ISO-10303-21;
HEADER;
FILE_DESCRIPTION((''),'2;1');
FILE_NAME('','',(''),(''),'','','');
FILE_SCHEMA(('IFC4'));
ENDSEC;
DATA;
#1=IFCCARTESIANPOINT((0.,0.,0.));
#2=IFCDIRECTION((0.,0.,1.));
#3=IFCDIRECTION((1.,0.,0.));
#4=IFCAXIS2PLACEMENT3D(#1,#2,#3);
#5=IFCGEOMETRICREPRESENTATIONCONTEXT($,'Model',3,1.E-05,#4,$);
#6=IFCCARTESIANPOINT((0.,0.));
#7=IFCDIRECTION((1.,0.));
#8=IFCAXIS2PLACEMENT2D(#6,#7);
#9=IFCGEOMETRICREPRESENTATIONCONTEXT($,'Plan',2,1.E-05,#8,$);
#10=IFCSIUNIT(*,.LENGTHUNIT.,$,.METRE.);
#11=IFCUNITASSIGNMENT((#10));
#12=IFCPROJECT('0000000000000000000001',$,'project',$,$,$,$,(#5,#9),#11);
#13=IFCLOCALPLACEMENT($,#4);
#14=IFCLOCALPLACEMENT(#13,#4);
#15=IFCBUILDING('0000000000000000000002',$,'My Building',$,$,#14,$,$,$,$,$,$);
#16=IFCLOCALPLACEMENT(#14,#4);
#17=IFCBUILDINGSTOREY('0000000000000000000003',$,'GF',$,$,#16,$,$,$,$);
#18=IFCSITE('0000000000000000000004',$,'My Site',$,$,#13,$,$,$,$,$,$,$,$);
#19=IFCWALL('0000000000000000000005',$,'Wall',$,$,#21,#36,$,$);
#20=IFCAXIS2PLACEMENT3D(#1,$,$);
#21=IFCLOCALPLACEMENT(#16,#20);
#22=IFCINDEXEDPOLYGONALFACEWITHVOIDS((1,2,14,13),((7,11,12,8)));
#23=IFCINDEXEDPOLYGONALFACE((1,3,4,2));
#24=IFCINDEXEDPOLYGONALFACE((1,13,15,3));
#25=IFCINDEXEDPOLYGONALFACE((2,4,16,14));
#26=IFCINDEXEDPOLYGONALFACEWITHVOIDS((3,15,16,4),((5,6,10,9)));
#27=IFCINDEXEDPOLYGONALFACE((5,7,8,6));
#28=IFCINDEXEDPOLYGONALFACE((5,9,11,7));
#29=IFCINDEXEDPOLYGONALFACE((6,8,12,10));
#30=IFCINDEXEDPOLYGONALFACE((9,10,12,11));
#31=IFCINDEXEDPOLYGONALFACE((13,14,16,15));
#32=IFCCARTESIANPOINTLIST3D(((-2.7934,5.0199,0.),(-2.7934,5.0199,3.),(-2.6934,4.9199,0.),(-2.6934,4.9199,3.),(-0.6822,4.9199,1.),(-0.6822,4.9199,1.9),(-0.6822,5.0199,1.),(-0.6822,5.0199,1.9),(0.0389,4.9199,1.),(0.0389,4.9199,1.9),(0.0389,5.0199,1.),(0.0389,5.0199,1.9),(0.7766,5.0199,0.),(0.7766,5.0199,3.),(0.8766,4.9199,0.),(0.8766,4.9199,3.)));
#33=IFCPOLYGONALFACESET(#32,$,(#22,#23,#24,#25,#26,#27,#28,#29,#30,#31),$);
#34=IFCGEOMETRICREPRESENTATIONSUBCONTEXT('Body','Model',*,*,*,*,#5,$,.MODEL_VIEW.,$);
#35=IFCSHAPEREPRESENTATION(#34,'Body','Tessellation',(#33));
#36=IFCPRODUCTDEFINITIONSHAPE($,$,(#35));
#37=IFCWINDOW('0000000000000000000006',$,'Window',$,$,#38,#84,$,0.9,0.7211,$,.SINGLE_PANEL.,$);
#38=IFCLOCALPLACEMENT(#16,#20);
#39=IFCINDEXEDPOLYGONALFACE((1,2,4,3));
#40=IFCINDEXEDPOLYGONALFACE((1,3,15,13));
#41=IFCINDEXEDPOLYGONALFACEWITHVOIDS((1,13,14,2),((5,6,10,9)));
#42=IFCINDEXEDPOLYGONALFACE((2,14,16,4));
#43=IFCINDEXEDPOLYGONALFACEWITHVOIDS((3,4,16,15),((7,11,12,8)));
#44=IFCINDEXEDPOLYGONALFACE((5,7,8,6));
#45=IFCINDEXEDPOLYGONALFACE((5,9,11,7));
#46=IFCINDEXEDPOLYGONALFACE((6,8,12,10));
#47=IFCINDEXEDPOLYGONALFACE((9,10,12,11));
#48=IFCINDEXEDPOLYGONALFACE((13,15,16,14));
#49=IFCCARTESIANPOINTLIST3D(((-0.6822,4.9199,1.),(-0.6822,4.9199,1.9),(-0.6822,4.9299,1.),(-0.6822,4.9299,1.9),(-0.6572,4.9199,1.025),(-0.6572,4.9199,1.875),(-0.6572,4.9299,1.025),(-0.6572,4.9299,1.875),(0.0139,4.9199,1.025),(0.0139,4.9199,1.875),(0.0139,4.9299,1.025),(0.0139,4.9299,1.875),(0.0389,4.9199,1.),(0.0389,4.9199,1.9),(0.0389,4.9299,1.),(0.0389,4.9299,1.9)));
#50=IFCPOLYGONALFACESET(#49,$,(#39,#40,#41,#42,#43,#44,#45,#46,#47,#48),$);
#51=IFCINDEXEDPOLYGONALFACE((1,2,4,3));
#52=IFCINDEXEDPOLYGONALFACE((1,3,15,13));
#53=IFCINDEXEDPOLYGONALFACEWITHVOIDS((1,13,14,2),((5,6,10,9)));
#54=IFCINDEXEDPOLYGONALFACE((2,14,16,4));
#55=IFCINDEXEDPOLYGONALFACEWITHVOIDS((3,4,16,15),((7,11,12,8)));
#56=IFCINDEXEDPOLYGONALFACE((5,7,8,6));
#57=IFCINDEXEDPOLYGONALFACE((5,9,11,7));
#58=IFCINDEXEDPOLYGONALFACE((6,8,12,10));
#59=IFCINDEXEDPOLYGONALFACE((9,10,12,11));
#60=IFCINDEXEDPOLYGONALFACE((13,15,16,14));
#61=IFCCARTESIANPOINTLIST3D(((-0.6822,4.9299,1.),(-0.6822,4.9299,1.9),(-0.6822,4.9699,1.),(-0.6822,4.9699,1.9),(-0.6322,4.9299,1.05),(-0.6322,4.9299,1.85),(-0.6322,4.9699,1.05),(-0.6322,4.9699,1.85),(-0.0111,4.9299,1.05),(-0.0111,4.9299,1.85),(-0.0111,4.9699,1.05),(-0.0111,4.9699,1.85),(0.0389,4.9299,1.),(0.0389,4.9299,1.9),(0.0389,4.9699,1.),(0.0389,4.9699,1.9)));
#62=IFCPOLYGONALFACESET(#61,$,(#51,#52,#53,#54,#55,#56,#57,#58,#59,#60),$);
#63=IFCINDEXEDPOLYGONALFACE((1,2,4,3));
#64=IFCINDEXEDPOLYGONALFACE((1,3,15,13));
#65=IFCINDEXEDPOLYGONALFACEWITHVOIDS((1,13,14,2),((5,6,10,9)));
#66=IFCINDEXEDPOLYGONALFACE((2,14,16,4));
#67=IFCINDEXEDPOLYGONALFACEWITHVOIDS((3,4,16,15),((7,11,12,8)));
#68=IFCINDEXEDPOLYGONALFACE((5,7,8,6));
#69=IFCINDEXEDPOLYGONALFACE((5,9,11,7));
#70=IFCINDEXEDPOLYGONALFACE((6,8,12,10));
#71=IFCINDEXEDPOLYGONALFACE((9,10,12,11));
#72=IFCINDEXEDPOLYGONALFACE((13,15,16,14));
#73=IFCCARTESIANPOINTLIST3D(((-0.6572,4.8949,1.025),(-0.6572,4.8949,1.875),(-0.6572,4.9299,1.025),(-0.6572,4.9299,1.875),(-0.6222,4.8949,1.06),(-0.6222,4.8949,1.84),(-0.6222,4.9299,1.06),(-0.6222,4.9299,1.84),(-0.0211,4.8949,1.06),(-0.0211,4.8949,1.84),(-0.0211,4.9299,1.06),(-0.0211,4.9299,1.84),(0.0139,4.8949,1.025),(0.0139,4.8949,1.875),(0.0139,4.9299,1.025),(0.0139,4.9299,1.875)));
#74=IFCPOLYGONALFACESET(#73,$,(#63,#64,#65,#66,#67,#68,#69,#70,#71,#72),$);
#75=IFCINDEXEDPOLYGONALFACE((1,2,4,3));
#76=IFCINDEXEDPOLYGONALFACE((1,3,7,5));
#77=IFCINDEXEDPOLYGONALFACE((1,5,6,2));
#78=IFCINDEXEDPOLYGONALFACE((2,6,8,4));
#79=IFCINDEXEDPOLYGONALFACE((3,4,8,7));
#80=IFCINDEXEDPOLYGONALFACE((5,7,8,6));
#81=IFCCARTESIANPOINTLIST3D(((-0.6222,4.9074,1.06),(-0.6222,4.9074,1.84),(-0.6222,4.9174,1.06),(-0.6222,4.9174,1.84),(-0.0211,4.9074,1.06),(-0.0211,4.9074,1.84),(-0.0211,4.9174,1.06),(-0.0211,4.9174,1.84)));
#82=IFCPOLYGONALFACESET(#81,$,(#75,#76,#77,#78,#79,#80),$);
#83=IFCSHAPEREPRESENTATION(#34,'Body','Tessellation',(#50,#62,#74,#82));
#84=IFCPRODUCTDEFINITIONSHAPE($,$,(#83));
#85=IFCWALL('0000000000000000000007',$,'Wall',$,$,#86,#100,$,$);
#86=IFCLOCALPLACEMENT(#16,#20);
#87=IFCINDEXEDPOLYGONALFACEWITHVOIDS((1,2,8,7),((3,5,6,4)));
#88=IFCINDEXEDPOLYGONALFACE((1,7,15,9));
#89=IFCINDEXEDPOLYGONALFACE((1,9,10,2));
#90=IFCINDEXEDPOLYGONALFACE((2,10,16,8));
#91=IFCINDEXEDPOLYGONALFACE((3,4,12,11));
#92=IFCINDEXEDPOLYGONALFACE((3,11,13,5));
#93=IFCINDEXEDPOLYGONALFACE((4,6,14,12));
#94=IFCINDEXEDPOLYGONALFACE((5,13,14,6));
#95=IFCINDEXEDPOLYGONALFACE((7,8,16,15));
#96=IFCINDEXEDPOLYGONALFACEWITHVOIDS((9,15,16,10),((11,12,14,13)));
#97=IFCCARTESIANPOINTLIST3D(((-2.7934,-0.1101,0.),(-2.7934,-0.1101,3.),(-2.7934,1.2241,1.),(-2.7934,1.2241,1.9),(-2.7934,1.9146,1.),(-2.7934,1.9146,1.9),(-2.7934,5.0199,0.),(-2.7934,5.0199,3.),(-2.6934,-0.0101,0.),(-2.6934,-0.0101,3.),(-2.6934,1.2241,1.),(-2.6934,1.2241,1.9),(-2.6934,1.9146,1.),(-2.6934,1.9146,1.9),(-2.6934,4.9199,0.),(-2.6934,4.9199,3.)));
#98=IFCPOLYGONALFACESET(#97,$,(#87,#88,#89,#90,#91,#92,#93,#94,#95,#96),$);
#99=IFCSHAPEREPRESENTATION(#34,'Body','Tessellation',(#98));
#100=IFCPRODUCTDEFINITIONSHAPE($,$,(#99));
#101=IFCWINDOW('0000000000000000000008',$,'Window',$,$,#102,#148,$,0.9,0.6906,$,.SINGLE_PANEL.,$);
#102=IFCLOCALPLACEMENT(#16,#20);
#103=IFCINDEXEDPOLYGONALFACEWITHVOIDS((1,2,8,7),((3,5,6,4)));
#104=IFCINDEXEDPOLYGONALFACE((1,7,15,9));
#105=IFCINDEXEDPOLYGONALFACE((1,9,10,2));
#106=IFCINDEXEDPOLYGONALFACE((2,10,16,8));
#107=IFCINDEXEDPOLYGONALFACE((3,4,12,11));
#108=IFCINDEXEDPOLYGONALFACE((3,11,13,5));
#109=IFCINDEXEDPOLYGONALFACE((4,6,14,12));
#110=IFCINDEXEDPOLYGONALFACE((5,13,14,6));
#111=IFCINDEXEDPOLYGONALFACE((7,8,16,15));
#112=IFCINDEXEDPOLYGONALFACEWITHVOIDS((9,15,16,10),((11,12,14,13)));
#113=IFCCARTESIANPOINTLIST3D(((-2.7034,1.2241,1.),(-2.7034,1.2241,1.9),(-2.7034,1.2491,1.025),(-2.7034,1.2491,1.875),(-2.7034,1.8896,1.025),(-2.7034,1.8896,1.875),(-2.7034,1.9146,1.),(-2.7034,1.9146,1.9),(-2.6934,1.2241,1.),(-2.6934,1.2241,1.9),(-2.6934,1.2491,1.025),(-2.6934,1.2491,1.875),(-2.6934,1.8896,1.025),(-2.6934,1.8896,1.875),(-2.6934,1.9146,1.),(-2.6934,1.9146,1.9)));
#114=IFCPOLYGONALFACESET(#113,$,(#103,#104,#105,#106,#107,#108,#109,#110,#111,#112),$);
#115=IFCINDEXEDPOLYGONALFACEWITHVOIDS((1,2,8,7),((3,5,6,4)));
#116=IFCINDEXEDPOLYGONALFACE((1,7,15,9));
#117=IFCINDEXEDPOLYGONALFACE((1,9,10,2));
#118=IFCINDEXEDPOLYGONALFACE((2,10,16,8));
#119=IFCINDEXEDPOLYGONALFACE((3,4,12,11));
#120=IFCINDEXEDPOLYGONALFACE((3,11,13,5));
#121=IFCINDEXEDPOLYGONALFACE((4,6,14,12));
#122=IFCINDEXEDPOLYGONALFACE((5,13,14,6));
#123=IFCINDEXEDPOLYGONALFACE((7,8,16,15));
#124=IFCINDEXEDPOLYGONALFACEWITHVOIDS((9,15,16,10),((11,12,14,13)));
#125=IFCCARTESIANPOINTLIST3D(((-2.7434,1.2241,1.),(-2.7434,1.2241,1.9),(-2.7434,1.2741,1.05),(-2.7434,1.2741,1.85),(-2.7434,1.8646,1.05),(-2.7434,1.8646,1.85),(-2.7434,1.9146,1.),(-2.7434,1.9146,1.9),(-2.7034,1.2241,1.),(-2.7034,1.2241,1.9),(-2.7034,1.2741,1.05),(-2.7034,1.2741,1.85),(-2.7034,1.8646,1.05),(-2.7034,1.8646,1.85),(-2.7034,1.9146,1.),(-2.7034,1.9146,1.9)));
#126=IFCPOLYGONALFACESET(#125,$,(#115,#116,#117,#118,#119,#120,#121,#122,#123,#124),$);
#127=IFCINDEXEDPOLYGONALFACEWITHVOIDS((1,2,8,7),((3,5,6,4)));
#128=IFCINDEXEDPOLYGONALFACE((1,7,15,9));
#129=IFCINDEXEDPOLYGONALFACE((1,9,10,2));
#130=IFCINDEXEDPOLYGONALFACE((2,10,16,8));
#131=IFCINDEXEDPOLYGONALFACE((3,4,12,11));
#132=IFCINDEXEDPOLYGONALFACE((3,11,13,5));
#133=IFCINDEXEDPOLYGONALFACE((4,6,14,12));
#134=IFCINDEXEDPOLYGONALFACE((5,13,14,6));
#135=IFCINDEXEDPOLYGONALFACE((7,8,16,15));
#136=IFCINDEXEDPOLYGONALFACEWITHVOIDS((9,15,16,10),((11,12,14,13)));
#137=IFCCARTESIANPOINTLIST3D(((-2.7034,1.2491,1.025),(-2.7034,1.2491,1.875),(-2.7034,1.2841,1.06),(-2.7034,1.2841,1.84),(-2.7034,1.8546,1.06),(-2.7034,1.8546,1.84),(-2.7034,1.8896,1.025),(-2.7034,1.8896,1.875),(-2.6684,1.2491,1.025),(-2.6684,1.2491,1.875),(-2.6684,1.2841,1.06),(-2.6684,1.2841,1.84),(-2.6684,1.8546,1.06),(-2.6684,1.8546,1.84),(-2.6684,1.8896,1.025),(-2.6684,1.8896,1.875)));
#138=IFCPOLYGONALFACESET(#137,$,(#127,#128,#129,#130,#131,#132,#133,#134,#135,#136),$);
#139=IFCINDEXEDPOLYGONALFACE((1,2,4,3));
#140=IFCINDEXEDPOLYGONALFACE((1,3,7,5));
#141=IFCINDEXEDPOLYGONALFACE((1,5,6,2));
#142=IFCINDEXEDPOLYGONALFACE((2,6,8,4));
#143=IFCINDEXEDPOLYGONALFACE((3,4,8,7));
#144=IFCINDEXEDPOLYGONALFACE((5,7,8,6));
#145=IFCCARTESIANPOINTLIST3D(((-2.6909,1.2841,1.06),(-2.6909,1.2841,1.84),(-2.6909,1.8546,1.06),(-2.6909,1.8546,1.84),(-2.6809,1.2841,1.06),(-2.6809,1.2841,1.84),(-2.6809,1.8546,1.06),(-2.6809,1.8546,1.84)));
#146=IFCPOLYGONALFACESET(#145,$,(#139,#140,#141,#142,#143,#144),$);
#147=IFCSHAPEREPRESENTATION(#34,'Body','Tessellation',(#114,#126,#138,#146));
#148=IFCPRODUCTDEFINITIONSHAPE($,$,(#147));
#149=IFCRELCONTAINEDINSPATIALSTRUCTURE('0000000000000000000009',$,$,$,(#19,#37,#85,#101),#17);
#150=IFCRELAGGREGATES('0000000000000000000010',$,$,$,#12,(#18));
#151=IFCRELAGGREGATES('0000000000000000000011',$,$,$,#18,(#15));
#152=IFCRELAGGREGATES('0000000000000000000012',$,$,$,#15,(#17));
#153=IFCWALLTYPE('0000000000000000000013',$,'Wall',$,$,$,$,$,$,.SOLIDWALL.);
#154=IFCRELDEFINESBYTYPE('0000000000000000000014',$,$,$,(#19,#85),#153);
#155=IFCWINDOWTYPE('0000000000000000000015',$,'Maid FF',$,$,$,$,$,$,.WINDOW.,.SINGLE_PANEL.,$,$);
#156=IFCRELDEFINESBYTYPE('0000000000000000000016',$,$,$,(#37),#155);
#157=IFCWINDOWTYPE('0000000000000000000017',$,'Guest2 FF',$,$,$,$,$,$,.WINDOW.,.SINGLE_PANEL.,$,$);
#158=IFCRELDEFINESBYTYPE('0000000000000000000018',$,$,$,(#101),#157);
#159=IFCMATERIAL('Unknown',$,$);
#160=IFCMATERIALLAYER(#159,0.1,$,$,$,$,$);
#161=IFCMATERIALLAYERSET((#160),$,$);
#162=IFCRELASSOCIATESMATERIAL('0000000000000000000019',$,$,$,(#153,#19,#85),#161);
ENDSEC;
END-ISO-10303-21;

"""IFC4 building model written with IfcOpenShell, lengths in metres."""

from ifc_helpers import new_model, entity, si_unit, frame, origin_with_axes, origin_2d_with_axis, place, context, subcontext, project, spatial, line, indexed_curve, outline, extrude, shape, source, transform, mapped, material, layer, layer_set, layer_usage, type_object, type_shapes, element, fill, save


model = new_model("IFC4")

# Units and contexts
model_context = context("Model", 3, precision=1e-05, world=origin_with_axes())
plan_context = context("Plan", 2, precision=1e-05, world=origin_2d_with_axis())
body_context_1 = subcontext(model_context, "Body", "Model", "MODEL_VIEW")
body_context_2 = subcontext(plan_context, "Body", "Plan", "PLAN_VIEW")
ifc_project = project(units=[si_unit("LENGTHUNIT", "METRE")], contexts=[model_context, plan_context])

# Site, building, storey
site_placement = place(None, origin_with_axes())
site = spatial("IfcSite", under=ifc_project, at=site_placement, Name="My Site")
building_placement = place(site_placement, origin_with_axes())
building = spatial("IfcBuilding", under=site, at=building_placement, Name="My Building")
storey_placement = place(building_placement, origin_with_axes())
storey = spatial("IfcBuildingStorey", under=building, at=storey_placement, Name="GF")

# Shared definitions
ifc_material_1 = material(Name="Unknown")

# Shared definitions
ifc_layer_1 = layer(ifc_material_1, 0.1)
ifc_layer_set_1 = layer_set([ifc_layer_1])
wall_type = type_object("IfcWallType", Name="Wall", PredefinedType="SOLIDWALL", material=ifc_layer_set_1)

# Walls, openings, windows
ifc_layer_usage_1 = layer_usage(ifc_layer_set_1, "AXIS2", "POSITIVE", 0.0)
wall_1_placement = place(storey_placement, frame((0.7766, 5.0199, 0.0), z_axis=(0.0, 0.0, 1.0), x_axis=(-1.0, 0.0, 0.0)))
wall_1 = element("IfcWall", 1, at=wall_1_placement, inside=storey, type_object=wall_type, material=ifc_layer_usage_1, Name="Wall", context=body_context_1, shape_type="SweptSolid", body=[
    extrude(outline(indexed_curve([(0.0, 0.0), (-0.1, 0.1), (3.47, 0.1), (3.57, 0.0)], segments=[line(1, 2, 3, 4, 1)])), origin_with_axes(), (0.0, 0.0, 1.0), 3.0),
])
shared_shape_1 = source(origin_with_axes(), body_context_1, "Body", "SweptSolid", [
    extrude(outline(indexed_curve([(0.0, 0.0), (0.7211, 0.0), (0.7211, 0.9), (0.0, 0.9)], segments=[line(1, 2, 3, 4, 1)])), frame((0.0, -0.6, 0.0), z_axis=(0.0, -1.0, 0.0), x_axis=(1.0, 0.0, 0.0)), (0.0, 0.0, -1.0), 1.2),
])
opening_1_placement = place(wall_1_placement, frame((0.7377, 0.0, 1.0), z_axis=(0.0, 0.0, 1.0), x_axis=(1.0, 0.0, 0.0)))
opening_1 = element("IfcOpeningElement", 2, at=opening_1_placement, cuts=wall_1, PredefinedType="OPENING", context=body_context_1, shape_type="MappedRepresentation", body=[
    mapped(shared_shape_1, transform((0.0, 0.0, 0.0), x_axis=(1.0, 0.0, 0.0), y_axis=(0.0, 1.0, 0.0), z_axis=(0.0, 0.0, 1.0), scale=1.0)),
])
window_type_1 = type_object("IfcWindowType", Name="Maid FF", PartitioningType="SINGLE_PANEL", PredefinedType="WINDOW")
shared_shape_2 = source(origin_with_axes(), body_context_1, "Body", "SweptSolid", [
    extrude(outline(indexed_curve([(0.0, 0.0), (0.7211, 0.0), (0.7211, 0.9), (0.0, 0.9)], segments=[line(1, 2, 3, 4, 1)]), holes=[indexed_curve([(0.025, 0.025), (0.6961, 0.025), (0.6961, 0.875), (0.025, 0.875)], segments=[line(1, 2, 3, 4, 1)])]), frame((0.0, 0.09, 0.0), z_axis=(0.0, -1.0, 0.0), x_axis=(1.0, 0.0, 0.0)), (0.0, 0.0, -1.0), 0.01),
    extrude(outline(indexed_curve([(0.0, 0.0), (0.7211, 0.0), (0.7211, 0.9), (0.0, 0.9)], segments=[line(1, 2, 3, 4, 1)]), holes=[indexed_curve([(0.05, 0.05), (0.6711, 0.05), (0.6711, 0.85), (0.05, 0.85)], segments=[line(1, 2, 3, 4, 1)])]), frame((0.0, 0.05, 0.0), z_axis=(0.0, -1.0, 0.0), x_axis=(1.0, 0.0, 0.0)), (0.0, 0.0, -1.0), 0.04),
    extrude(outline(indexed_curve([(0.0, 0.0), (0.6711, 0.0), (0.6711, 0.85), (0.0, 0.85)], segments=[line(1, 2, 3, 4, 1)]), holes=[indexed_curve([(0.035, 0.035), (0.6361, 0.035), (0.6361, 0.815), (0.035, 0.815)], segments=[line(1, 2, 3, 4, 1)])]), frame((0.025, 0.09, 0.025), z_axis=(0.0, -1.0, 0.0), x_axis=(1.0, 0.0, 0.0)), (0.0, 0.0, -1.0), 0.035),
    extrude(outline(indexed_curve([(0.035, 0.035), (0.6361, 0.035), (0.6361, 0.815), (0.035, 0.815)], segments=[line(1, 2, 3, 4, 1)])), frame((0.025, 0.1025, 0.025), z_axis=(0.0, -1.0, 0.0), x_axis=(1.0, 0.0, 0.0)), (0.0, 0.0, -1.0), 0.01),
])
shared_shape_3 = source(origin_with_axes(), body_context_2, "Body", "Curve2D", [
    entity("IfcIndexedPolyCurve", entity("IfcCartesianPointList2D", [[0.05, 0.05], [0.6711, 0.05]])),
    entity("IfcIndexedPolyCurve", entity("IfcCartesianPointList2D", [[0.0, 0.1], [0.025, 0.1], [0.025, 0.09], [0.05, 0.09], [0.05, 0.05], [0.0, 0.05]]), [entity("IfcLineIndex", [1, 2, 3, 4, 5, 6, 1])]),
    entity("IfcIndexedPolyCurve", entity("IfcCartesianPointList2D", [[0.7211, 0.1], [0.6961, 0.1], [0.6961, 0.09], [0.6711, 0.09], [0.6711, 0.05], [0.7211, 0.05]]), [entity("IfcLineIndex", [1, 2, 3, 4, 5, 6, 1])]),
    entity("IfcIndexedPolyCurve", entity("IfcCartesianPointList2D", [[0.025, 0.09], [0.06, 0.09], [0.06, 0.125], [0.025, 0.125]]), [entity("IfcLineIndex", [1, 2, 3, 4, 1])]),
    entity("IfcIndexedPolyCurve", entity("IfcCartesianPointList2D", [[0.6961, 0.09], [0.6611, 0.09], [0.6611, 0.125], [0.6961, 0.125]]), [entity("IfcLineIndex", [1, 2, 3, 4, 1])]),
    entity("IfcIndexedPolyCurve", entity("IfcCartesianPointList2D", [[0.06, 0.09], [0.6611, 0.09]])),
    entity("IfcIndexedPolyCurve", entity("IfcCartesianPointList2D", [[0.06, 0.125], [0.6611, 0.125]])),
    entity("IfcIndexedPolyCurve", entity("IfcCartesianPointList2D", [[0.06, 0.1075], [0.6611, 0.1075]])),
])
type_shapes(window_type_1, [shared_shape_2, shared_shape_3])
window_1_placement = place(opening_1_placement, frame((0.0, 0.0, 0.0), z_axis=(0.0, 0.0, 1.0), x_axis=(1.0, 0.0, 0.0)))
window_1 = element("IfcWindow", 3, at=window_1_placement, inside=storey, type_object=window_type_1, Name="Window", OverallHeight=0.9, OverallWidth=0.7211, PartitioningType="SINGLE_PANEL", shapes=[
    shape(body_context_1, "Body", "MappedRepresentation", [mapped(shared_shape_2, transform((0.0, 0.0, 0.0), x_axis=(1.0, 0.0, 0.0), y_axis=(0.0, 1.0, 0.0), z_axis=(0.0, 0.0, 1.0), scale=1.0))]),
    shape(body_context_2, "Body", "MappedRepresentation", [mapped(shared_shape_3, transform((0.0, 0.0, 0.0), x_axis=(1.0, 0.0, 0.0), y_axis=(0.0, 1.0, 0.0), z_axis=(0.0, 0.0, 1.0), scale=1.0))]),
])
fill(opening_1, window_1)
ifc_layer_usage_2 = layer_usage(ifc_layer_set_1, "AXIS2", "POSITIVE", 0.0)
wall_2_placement = place(storey_placement, frame((-2.7934, 5.0199, 0.0), z_axis=(0.0, 0.0, 1.0), x_axis=(0.0, -1.0, 0.0)))
wall_2 = element("IfcWall", 4, at=wall_2_placement, inside=storey, type_object=wall_type, material=ifc_layer_usage_2, Name="Wall", context=body_context_1, shape_type="SweptSolid", body=[
    extrude(outline(indexed_curve([(0.0, 0.0), (0.1, 0.1), (5.03, 0.1), (5.13, 0.0)], segments=[line(1, 2, 3, 4, 1)])), origin_with_axes(), (0.0, 0.0, 1.0), 3.0),
])
shared_shape_4 = source(origin_with_axes(), body_context_1, "Body", "SweptSolid", [
    extrude(outline(indexed_curve([(0.0, 0.0), (0.6906, 0.0), (0.6906, 0.9), (0.0, 0.9)], segments=[line(1, 2, 3, 4, 1)])), frame((0.0, -0.6, 0.0), z_axis=(0.0, -1.0, 0.0), x_axis=(1.0, 0.0, 0.0)), (0.0, 0.0, -1.0), 1.2),
])
opening_2_placement = place(wall_2_placement, frame((3.1053, 0.0, 1.0), z_axis=(0.0, 0.0, 1.0), x_axis=(1.0, 0.0, 0.0)))
opening_2 = element("IfcOpeningElement", 5, at=opening_2_placement, cuts=wall_2, PredefinedType="OPENING", context=body_context_1, shape_type="MappedRepresentation", body=[
    mapped(shared_shape_4, transform((0.0, 0.0, 0.0), x_axis=(1.0, 0.0, 0.0), y_axis=(0.0, 1.0, 0.0), z_axis=(0.0, 0.0, 1.0), scale=1.0)),
])
window_type_2 = type_object("IfcWindowType", Name="Guest2 FF", PartitioningType="SINGLE_PANEL", PredefinedType="WINDOW")
shared_shape_5 = source(origin_with_axes(), body_context_1, "Body", "SweptSolid", [
    extrude(outline(indexed_curve([(0.0, 0.0), (0.6906, 0.0), (0.6906, 0.9), (0.0, 0.9)], segments=[line(1, 2, 3, 4, 1)]), holes=[indexed_curve([(0.025, 0.025), (0.6656, 0.025), (0.6656, 0.875), (0.025, 0.875)], segments=[line(1, 2, 3, 4, 1)])]), frame((0.0, 0.09, 0.0), z_axis=(0.0, -1.0, 0.0), x_axis=(1.0, 0.0, 0.0)), (0.0, 0.0, -1.0), 0.01),
    extrude(outline(indexed_curve([(0.0, 0.0), (0.6906, 0.0), (0.6906, 0.9), (0.0, 0.9)], segments=[line(1, 2, 3, 4, 1)]), holes=[indexed_curve([(0.05, 0.05), (0.6406, 0.05), (0.6406, 0.85), (0.05, 0.85)], segments=[line(1, 2, 3, 4, 1)])]), frame((0.0, 0.05, 0.0), z_axis=(0.0, -1.0, 0.0), x_axis=(1.0, 0.0, 0.0)), (0.0, 0.0, -1.0), 0.04),
    extrude(outline(indexed_curve([(0.0, 0.0), (0.6406, 0.0), (0.6406, 0.85), (0.0, 0.85)], segments=[line(1, 2, 3, 4, 1)]), holes=[indexed_curve([(0.035, 0.035), (0.6056, 0.035), (0.6056, 0.815), (0.035, 0.815)], segments=[line(1, 2, 3, 4, 1)])]), frame((0.025, 0.09, 0.025), z_axis=(0.0, -1.0, 0.0), x_axis=(1.0, 0.0, 0.0)), (0.0, 0.0, -1.0), 0.035),
    extrude(outline(indexed_curve([(0.035, 0.035), (0.6056, 0.035), (0.6056, 0.815), (0.035, 0.815)], segments=[line(1, 2, 3, 4, 1)])), frame((0.025, 0.1025, 0.025), z_axis=(0.0, -1.0, 0.0), x_axis=(1.0, 0.0, 0.0)), (0.0, 0.0, -1.0), 0.01),
])
shared_shape_6 = source(origin_with_axes(), body_context_2, "Body", "Curve2D", [
    entity("IfcIndexedPolyCurve", entity("IfcCartesianPointList2D", [[0.05, 0.05], [0.6406, 0.05]])),
    entity("IfcIndexedPolyCurve", entity("IfcCartesianPointList2D", [[0.0, 0.1], [0.025, 0.1], [0.025, 0.09], [0.05, 0.09], [0.05, 0.05], [0.0, 0.05]]), [entity("IfcLineIndex", [1, 2, 3, 4, 5, 6, 1])]),
    entity("IfcIndexedPolyCurve", entity("IfcCartesianPointList2D", [[0.6906, 0.1], [0.6656, 0.1], [0.6656, 0.09], [0.6406, 0.09], [0.6406, 0.05], [0.6906, 0.05]]), [entity("IfcLineIndex", [1, 2, 3, 4, 5, 6, 1])]),
    entity("IfcIndexedPolyCurve", entity("IfcCartesianPointList2D", [[0.025, 0.09], [0.06, 0.09], [0.06, 0.125], [0.025, 0.125]]), [entity("IfcLineIndex", [1, 2, 3, 4, 1])]),
    entity("IfcIndexedPolyCurve", entity("IfcCartesianPointList2D", [[0.6656, 0.09], [0.6306, 0.09], [0.6306, 0.125], [0.6656, 0.125]]), [entity("IfcLineIndex", [1, 2, 3, 4, 1])]),
    entity("IfcIndexedPolyCurve", entity("IfcCartesianPointList2D", [[0.06, 0.09], [0.6306, 0.09]])),
    entity("IfcIndexedPolyCurve", entity("IfcCartesianPointList2D", [[0.06, 0.125], [0.6306, 0.125]])),
    entity("IfcIndexedPolyCurve", entity("IfcCartesianPointList2D", [[0.06, 0.1075], [0.6306, 0.1075]])),
])
type_shapes(window_type_2, [shared_shape_5, shared_shape_6])
window_2_placement = place(opening_2_placement, frame((0.0, 0.0, 0.0), z_axis=(0.0, 0.0, 1.0), x_axis=(1.0, 0.0, 0.0)))
window_2 = element("IfcWindow", 6, at=window_2_placement, inside=storey, type_object=window_type_2, Name="Window", OverallHeight=0.9, OverallWidth=0.6906, PartitioningType="SINGLE_PANEL", shapes=[
    shape(body_context_1, "Body", "MappedRepresentation", [mapped(shared_shape_5, transform((0.0, 0.0, 0.0), x_axis=(1.0, 0.0, 0.0), y_axis=(0.0, 1.0, 0.0), z_axis=(0.0, 0.0, 1.0), scale=1.0))]),
    shape(body_context_2, "Body", "MappedRepresentation", [mapped(shared_shape_6, transform((0.0, 0.0, 0.0), x_axis=(1.0, 0.0, 0.0), y_axis=(0.0, 1.0, 0.0), z_axis=(0.0, 0.0, 1.0), scale=1.0))]),
])
fill(opening_2, window_2)

save(model, "model.ifc")
